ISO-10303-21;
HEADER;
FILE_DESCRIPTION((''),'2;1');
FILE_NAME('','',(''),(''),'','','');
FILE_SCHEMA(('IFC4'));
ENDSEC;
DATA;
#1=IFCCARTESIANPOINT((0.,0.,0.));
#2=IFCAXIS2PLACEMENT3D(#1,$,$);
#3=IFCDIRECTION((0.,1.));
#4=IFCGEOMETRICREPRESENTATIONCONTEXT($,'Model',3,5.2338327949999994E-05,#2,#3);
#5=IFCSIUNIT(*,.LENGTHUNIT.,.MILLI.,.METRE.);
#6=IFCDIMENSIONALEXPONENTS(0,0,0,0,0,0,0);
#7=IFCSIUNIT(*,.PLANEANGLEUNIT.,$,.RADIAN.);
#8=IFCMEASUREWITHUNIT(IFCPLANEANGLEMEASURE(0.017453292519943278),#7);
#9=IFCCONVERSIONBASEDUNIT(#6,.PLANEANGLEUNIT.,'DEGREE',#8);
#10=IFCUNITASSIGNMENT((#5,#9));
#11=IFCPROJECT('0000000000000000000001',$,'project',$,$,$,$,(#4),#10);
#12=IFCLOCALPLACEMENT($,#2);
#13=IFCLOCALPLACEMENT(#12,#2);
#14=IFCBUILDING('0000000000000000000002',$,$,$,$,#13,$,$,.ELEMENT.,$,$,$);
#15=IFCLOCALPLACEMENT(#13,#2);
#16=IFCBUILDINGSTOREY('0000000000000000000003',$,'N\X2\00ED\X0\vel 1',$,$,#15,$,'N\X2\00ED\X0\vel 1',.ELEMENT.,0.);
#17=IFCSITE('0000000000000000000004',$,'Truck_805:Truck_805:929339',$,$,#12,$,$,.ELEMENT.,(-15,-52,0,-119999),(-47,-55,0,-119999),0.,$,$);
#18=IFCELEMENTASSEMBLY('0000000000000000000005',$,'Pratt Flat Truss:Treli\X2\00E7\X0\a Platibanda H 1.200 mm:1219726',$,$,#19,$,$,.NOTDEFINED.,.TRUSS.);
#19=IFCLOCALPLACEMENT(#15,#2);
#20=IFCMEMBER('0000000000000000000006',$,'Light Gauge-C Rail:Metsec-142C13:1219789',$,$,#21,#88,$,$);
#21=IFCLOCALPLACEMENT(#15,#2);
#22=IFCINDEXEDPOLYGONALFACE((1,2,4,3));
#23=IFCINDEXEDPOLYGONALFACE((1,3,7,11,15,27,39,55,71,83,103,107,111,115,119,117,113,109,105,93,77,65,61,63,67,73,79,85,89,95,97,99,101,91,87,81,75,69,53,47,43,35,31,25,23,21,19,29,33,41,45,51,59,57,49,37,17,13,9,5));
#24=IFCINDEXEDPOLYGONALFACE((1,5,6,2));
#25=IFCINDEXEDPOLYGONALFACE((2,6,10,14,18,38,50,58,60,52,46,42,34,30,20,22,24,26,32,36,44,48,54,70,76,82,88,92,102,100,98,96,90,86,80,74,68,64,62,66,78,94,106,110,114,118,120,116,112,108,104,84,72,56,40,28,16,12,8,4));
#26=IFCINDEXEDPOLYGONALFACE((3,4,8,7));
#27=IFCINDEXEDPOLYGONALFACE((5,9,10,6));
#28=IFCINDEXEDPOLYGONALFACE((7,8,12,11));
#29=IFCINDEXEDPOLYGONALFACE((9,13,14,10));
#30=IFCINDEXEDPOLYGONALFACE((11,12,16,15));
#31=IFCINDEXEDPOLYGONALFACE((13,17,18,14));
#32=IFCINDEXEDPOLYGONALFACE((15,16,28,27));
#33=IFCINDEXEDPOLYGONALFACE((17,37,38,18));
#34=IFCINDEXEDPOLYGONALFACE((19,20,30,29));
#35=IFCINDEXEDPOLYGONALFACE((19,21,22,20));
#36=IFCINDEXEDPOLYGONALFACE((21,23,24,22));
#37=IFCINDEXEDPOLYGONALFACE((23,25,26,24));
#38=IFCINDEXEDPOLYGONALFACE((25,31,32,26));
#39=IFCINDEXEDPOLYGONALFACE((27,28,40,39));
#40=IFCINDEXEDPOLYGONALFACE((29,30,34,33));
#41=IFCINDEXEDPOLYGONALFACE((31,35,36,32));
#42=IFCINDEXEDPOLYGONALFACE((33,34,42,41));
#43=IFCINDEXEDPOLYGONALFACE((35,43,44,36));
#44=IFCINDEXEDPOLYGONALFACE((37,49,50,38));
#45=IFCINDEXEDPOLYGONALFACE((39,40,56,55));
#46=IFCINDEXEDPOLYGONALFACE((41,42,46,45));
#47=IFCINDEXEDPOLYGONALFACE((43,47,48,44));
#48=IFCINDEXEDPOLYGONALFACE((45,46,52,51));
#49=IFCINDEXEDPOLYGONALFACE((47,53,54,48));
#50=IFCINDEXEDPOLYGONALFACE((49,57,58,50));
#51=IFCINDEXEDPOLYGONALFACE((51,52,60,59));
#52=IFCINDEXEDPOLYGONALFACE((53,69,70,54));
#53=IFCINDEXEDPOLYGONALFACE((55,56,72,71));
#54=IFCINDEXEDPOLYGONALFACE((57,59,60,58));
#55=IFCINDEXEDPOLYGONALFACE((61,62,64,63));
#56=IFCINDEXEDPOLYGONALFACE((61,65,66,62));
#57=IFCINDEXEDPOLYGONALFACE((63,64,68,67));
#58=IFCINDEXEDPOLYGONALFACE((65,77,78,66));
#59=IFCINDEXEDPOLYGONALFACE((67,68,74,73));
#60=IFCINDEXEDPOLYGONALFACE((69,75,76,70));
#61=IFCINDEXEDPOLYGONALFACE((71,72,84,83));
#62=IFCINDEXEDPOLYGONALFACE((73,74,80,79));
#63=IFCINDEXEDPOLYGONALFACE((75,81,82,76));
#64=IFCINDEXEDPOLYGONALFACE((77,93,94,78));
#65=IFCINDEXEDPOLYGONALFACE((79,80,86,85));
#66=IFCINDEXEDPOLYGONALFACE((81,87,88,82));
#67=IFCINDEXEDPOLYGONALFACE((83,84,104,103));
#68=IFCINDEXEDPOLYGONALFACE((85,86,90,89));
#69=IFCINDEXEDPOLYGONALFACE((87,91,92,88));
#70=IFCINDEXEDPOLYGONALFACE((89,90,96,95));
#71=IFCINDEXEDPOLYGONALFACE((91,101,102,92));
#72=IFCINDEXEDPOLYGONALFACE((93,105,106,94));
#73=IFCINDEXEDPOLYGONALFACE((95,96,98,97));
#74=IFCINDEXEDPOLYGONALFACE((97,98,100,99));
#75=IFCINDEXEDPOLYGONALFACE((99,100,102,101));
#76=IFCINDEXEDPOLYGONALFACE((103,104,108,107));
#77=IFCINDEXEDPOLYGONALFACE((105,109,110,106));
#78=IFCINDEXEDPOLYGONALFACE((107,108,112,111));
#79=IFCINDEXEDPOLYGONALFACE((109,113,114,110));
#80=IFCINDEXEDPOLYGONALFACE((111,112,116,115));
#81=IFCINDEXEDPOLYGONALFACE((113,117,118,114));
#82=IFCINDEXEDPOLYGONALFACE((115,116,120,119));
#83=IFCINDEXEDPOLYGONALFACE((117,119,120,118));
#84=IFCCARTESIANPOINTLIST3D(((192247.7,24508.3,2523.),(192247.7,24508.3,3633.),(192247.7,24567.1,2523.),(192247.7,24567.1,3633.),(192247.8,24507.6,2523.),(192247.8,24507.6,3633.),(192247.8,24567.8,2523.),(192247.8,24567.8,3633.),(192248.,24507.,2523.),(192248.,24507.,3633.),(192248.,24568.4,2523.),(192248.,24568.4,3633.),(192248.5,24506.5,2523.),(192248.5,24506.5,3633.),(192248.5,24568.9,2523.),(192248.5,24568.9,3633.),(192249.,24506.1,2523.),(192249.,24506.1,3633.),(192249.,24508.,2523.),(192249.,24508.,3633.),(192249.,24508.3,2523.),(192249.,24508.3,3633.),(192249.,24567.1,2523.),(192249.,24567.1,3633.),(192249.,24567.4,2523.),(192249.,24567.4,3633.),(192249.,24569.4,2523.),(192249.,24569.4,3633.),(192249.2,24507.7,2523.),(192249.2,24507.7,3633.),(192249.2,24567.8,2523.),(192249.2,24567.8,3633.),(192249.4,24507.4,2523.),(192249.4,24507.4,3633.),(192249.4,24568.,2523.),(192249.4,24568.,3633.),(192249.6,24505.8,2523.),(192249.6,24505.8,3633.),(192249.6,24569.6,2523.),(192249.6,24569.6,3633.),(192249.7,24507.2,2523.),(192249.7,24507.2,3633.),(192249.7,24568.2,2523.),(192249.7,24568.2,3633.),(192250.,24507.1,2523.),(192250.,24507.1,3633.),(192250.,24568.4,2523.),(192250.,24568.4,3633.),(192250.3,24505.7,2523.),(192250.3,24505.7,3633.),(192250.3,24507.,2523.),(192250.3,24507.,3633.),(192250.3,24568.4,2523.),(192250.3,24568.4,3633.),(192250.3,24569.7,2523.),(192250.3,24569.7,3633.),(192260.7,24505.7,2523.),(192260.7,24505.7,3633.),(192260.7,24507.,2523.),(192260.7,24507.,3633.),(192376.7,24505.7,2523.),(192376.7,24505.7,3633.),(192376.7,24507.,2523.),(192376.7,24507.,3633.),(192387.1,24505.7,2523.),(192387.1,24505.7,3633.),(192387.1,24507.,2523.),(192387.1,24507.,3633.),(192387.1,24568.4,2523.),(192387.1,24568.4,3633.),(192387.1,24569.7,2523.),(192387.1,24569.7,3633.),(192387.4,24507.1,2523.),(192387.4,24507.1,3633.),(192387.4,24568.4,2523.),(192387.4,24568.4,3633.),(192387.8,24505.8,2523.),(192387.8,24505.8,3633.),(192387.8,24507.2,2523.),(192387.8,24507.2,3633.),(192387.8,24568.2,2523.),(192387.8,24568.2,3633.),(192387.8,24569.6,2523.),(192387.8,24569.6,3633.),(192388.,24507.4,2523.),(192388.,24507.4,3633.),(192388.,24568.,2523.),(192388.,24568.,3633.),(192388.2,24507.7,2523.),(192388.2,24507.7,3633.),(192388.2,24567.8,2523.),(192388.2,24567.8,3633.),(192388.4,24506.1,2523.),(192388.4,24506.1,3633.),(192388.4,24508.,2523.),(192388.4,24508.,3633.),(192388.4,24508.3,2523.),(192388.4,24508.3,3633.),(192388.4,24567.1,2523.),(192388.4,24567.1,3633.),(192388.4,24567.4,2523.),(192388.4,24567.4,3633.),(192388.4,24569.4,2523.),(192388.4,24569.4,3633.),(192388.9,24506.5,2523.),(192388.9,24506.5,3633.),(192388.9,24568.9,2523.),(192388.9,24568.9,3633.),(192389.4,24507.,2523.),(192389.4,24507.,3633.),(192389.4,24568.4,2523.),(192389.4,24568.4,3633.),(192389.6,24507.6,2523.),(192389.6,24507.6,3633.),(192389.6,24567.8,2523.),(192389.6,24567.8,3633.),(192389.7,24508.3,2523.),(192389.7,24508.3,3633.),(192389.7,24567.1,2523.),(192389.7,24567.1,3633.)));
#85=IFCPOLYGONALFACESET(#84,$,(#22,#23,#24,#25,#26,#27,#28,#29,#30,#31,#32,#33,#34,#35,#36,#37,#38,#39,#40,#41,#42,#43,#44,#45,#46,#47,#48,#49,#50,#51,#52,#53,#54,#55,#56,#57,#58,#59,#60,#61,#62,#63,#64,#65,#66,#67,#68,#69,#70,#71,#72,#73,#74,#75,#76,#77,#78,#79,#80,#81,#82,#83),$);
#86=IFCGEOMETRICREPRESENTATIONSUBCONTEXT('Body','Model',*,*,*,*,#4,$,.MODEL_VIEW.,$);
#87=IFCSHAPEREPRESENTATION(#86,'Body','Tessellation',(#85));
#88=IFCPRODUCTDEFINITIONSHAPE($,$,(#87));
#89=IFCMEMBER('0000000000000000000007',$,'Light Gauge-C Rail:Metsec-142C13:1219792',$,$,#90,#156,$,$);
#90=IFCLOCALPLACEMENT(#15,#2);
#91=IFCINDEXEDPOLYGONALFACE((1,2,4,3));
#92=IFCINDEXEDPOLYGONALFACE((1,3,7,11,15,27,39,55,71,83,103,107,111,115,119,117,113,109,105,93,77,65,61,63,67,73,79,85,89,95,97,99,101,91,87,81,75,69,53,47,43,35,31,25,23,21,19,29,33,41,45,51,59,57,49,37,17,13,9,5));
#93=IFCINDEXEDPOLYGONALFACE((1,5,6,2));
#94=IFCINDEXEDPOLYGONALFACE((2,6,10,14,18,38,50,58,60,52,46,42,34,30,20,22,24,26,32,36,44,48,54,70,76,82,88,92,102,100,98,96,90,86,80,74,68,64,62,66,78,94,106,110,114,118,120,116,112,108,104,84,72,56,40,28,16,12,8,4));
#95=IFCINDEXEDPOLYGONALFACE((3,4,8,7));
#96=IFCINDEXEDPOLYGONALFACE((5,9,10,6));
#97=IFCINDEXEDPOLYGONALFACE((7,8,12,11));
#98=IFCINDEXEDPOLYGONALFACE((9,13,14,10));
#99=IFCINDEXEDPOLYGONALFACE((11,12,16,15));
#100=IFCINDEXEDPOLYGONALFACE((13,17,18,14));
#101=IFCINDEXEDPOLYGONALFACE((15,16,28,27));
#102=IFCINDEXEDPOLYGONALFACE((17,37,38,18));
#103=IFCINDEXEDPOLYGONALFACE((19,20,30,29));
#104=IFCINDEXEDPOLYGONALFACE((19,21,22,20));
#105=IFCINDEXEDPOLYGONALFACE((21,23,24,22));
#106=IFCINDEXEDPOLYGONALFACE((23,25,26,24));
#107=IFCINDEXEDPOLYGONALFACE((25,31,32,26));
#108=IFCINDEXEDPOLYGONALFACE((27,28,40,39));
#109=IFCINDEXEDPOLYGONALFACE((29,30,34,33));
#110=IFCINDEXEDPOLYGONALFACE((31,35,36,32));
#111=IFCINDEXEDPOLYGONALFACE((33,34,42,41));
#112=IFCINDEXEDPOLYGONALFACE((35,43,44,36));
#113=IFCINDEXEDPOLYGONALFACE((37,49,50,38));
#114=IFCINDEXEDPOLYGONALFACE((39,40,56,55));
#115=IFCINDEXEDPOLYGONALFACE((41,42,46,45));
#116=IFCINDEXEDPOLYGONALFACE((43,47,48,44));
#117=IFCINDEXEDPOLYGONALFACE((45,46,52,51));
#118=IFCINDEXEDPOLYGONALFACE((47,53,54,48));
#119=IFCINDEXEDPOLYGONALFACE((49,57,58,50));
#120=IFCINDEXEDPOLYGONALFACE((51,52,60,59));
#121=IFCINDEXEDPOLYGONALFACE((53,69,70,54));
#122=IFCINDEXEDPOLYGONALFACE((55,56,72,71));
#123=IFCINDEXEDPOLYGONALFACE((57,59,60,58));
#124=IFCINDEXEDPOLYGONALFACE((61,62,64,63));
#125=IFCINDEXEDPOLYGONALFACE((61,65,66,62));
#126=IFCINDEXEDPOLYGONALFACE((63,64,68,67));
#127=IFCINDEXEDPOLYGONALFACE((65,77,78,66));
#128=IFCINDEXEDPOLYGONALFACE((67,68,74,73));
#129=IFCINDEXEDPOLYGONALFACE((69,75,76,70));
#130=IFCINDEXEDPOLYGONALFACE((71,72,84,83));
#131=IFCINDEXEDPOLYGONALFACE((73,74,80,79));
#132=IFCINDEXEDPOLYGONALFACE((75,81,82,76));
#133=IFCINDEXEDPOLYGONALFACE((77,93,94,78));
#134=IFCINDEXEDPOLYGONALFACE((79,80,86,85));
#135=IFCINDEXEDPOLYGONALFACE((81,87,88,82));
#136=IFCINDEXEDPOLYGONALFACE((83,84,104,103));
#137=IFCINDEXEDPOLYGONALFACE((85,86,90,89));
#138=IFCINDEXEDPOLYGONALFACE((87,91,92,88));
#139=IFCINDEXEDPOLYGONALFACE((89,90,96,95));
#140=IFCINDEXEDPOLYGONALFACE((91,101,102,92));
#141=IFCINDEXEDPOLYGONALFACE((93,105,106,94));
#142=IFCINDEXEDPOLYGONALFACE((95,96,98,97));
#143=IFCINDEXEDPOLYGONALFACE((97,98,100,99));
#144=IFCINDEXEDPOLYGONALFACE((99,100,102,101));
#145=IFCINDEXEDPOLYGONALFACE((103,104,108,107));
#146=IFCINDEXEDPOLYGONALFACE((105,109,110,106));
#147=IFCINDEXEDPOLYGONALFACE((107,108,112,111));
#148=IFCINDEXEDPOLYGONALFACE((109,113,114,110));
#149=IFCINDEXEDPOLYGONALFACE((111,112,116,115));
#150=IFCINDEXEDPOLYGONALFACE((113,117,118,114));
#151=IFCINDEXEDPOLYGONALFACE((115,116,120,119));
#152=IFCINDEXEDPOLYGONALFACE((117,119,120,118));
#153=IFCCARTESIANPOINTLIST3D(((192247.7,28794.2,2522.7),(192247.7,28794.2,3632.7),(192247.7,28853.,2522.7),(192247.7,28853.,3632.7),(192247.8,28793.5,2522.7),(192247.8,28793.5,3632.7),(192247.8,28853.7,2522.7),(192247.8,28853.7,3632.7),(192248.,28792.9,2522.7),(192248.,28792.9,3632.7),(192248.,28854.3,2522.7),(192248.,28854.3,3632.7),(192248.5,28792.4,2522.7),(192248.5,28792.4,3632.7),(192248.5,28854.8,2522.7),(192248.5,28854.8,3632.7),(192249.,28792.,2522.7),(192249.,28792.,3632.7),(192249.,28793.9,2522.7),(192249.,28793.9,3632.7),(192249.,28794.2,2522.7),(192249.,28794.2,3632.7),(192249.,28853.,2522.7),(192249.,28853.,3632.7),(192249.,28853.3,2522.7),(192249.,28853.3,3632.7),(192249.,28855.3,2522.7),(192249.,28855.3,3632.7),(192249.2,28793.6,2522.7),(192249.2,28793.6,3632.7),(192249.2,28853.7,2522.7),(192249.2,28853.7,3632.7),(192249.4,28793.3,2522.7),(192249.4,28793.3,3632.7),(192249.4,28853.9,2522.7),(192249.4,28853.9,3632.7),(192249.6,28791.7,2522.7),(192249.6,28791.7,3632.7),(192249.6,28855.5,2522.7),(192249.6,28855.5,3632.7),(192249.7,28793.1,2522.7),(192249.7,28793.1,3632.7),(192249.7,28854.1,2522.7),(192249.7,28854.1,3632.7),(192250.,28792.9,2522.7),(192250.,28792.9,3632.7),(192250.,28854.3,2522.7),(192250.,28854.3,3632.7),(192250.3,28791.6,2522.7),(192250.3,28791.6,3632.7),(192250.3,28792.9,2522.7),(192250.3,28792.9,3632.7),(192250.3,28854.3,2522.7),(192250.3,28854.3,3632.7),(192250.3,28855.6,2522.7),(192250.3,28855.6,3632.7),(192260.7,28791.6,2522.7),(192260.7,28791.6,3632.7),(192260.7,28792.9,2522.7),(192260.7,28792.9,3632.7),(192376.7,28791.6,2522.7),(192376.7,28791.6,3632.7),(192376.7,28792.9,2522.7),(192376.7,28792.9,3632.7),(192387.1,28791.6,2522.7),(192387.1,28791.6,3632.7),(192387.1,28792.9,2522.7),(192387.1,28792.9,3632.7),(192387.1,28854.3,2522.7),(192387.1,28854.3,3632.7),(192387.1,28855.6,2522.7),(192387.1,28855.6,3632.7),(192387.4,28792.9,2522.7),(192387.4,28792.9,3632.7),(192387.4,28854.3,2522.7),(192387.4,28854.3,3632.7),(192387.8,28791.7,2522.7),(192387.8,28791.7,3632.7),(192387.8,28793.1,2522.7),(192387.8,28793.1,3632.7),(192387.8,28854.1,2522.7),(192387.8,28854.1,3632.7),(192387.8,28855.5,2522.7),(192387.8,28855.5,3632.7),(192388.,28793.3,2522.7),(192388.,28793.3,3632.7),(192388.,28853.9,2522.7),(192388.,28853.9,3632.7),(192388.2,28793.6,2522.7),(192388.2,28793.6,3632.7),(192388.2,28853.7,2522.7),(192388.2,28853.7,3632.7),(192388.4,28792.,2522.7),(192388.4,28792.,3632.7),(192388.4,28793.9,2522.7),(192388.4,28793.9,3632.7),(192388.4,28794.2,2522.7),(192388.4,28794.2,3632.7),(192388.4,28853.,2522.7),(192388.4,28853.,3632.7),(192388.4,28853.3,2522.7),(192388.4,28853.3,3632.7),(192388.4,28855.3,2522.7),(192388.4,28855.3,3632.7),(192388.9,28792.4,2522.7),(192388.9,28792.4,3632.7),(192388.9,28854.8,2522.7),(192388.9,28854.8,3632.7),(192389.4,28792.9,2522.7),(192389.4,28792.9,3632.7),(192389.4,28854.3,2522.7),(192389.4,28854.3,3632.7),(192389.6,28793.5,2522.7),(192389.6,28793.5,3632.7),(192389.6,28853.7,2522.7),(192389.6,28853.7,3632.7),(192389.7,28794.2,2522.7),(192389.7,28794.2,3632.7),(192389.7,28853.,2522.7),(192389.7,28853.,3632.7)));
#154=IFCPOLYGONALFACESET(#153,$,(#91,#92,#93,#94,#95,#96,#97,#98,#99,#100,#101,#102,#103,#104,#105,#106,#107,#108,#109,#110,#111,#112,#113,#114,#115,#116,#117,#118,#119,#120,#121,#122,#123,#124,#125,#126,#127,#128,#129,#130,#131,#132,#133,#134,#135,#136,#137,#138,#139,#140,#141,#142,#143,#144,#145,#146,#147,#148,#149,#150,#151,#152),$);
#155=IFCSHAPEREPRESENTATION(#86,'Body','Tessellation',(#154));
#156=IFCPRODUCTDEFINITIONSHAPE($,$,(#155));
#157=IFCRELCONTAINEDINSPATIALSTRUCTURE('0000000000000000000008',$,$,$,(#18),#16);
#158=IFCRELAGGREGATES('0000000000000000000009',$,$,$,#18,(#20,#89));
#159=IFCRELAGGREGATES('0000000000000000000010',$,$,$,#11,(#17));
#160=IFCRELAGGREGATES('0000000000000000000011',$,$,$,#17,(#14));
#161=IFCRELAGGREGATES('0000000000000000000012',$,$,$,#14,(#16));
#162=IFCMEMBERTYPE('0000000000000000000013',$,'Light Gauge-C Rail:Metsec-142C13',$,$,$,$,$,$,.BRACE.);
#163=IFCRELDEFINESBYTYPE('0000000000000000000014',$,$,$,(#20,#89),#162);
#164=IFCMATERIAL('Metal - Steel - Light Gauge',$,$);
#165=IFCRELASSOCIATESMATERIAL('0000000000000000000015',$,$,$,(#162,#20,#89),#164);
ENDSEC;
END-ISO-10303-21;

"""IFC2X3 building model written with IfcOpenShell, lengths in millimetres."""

from ifc_helpers import new_model, entity, si_unit, converted_unit, direction, frame, frame_2d, origin, place, context, subcontext, project, spatial, polyline, circle_curve, parameter, trimmed, segment, composite_curve, outline, extrude, source, transform, mapped, material, type_object, type_shapes, element, aggregate, save


model = new_model("IFC2X3")

# Units and contexts
model_context = context("Model", 3, precision=5.2338327949999994e-05, world=origin(), true_north=direction((0.0, 1.0)))
body_context = subcontext(model_context, "Body", "Model", "MODEL_VIEW")
ifc_project = project(units=[si_unit("LENGTHUNIT", "METRE", prefix="MILLI"), converted_unit("PLANEANGLEUNIT", "DEGREE", entity("IfcPlaneAngleMeasure", 0.017453292519943278), si_unit("PLANEANGLEUNIT", "RADIAN"), dimensions=[0, 0, 0, 0, 0, 0, 0])], contexts=[model_context])

# Site, building, storey
site_placement = place(None, origin())
site = spatial("IfcSite", under=ifc_project, at=site_placement, Name="Truck_805:Truck_805:929339", CompositionType="ELEMENT", RefLatitude=(-15, -52, 0, -119999), RefLongitude=(-47, -55, 0, -119999), RefElevation=0.0)
building_placement = place(site_placement, origin())
building = spatial("IfcBuilding", under=site, at=building_placement, CompositionType="ELEMENT")
storey_placement = place(building_placement, origin())
storey = spatial("IfcBuildingStorey", under=building, at=storey_placement, Name="Nível 1", LongName="Nível 1", CompositionType="ELEMENT", Elevation=0.0)

# Element assembly, members
assembly_1_placement = place(storey_placement, origin())
assembly_1 = element("IfcElementAssembly", 1, at=assembly_1_placement, inside=storey, Name="Pratt Flat Truss:Treliça Platibanda H 1.200 mm:1219726", AssemblyPlace="NOTDEFINED", PredefinedType="TRUSS")
ifc_material_1 = material(Name="Metal - Steel - Light Gauge")
member_type_1 = type_object("IfcMemberType", Name="Light Gauge-C Rail:Metsec-142C13", PredefinedType="BRACE", material=ifc_material_1)
shared_shape_1 = source(origin(), body_context, "Body", "SweptSolid", [
    extrude(outline(composite_curve([segment(polyline([(-23.1, -71.0), (35.7, -71.0)]), True, "CONTINUOUS"), segment(trimmed(circle_curve(frame_2d((35.7, -68.4), x_axis=(0.0, -1.0)), 2.6), [parameter(0.0)], [parameter(90.0)], True, "PARAMETER"), True, "CONTINUOUS"), segment(polyline([(38.3, -68.4), (38.3, 68.4)]), True, "CONTINUOUS"), segment(trimmed(circle_curve(frame_2d((35.7, 68.4), x_axis=(1.0, 0.0)), 2.6), [parameter(0.0)], [parameter(90.0)], True, "PARAMETER"), True, "CONTINUOUS"), segment(polyline([(35.7, 71.0), (-23.1, 71.0)]), True, "CONTINUOUS"), segment(trimmed(circle_curve(frame_2d((-23.1, 68.4), x_axis=(0.0, 1.0)), 2.6), [parameter(0.0)], [parameter(90.0)], True, "PARAMETER"), True, "CONTINUOUS"), segment(polyline([(-25.7, 68.4), (-25.7, 58.0)]), True, "CONTINUOUS"), segment(polyline([(-25.7, 58.0), (-24.4, 58.0)]), True, "CONTINUOUS"), segment(polyline([(-24.4, 58.0), (-24.4, 68.4)]), True, "CONTINUOUS"), segment(trimmed(circle_curve(frame_2d((-23.1, 68.4), x_axis=(-1.0, 0.0)), 1.3), [parameter(270.0)], [parameter(0.0)], True, "PARAMETER"), False, "CONTINUOUS"), segment(polyline([(-23.1, 69.7), (35.7, 69.7)]), True, "CONTINUOUS"), segment(trimmed(circle_curve(frame_2d((35.7, 68.4), x_axis=(0.0, 1.0)), 1.3), [parameter(270.0)], [parameter(0.0)], True, "PARAMETER"), False, "CONTINUOUS"), segment(polyline([(37.0, 68.4), (37.0, -68.4)]), True, "CONTINUOUS"), segment(trimmed(circle_curve(frame_2d((35.7, -68.4), x_axis=(1.0, 0.0)), 1.3), [parameter(270.0)], [parameter(0.0)], True, "PARAMETER"), False, "CONTINUOUS"), segment(polyline([(35.7, -69.7), (-23.1, -69.7)]), True, "CONTINUOUS"), segment(trimmed(circle_curve(frame_2d((-23.1, -68.4), x_axis=(0.0, -1.0)), 1.3), [parameter(270.0)], [parameter(0.0)], True, "PARAMETER"), False, "CONTINUOUS"), segment(polyline([(-24.4, -68.4), (-24.4, -58.0)]), True, "CONTINUOUS"), segment(polyline([(-24.4, -58.0), (-25.7, -58.0)]), True, "CONTINUOUS"), segment(polyline([(-25.7, -58.0), (-25.7, -68.4)]), True, "CONTINUOUS"), segment(trimmed(circle_curve(frame_2d((-23.1, -68.4), x_axis=(-1.0, 0.0)), 2.6), [parameter(0.0)], [parameter(90.0)], True, "PARAMETER"), True, "CONTINUOUS")], self_intersect=False)), frame((-555.0, 0.0, 18.8), z_axis=(1.0, 0.0, 0.0), x_axis=(0.0, 0.0, -1.0)), (0.0, 0.0, 1.0), 1110.0),
])
type_shapes(member_type_1, [shared_shape_1])
member_1_placement = place(assembly_1_placement, frame((192318.7, 24550.2, 3078.0), z_axis=(0.0, -1.0, 0.0), x_axis=(0.0, 0.0, 1.0)))
member_1 = element("IfcMember", 2, at=member_1_placement, type_object=member_type_1, material=ifc_material_1, Name="Light Gauge-C Rail:Metsec-142C13:1219789", context=body_context, shape_type="MappedRepresentation", body=[
    mapped(shared_shape_1, transform((0.0, 0.0, 0.0), scale=1.0)),
])
member_2_placement = place(assembly_1_placement, frame((192318.7, 28836.1, 3077.7), z_axis=(0.0, -1.0, 0.0), x_axis=(0.0, 0.0, 1.0)))
member_2 = element("IfcMember", 3, at=member_2_placement, type_object=member_type_1, material=ifc_material_1, Name="Light Gauge-C Rail:Metsec-142C13:1219792", context=body_context, shape_type="MappedRepresentation", body=[
    mapped(shared_shape_1, transform((0.0, 0.0, 0.0), scale=1.0)),
])
aggregate(assembly_1, [member_1, member_2])

save(model, "model.ifc")
